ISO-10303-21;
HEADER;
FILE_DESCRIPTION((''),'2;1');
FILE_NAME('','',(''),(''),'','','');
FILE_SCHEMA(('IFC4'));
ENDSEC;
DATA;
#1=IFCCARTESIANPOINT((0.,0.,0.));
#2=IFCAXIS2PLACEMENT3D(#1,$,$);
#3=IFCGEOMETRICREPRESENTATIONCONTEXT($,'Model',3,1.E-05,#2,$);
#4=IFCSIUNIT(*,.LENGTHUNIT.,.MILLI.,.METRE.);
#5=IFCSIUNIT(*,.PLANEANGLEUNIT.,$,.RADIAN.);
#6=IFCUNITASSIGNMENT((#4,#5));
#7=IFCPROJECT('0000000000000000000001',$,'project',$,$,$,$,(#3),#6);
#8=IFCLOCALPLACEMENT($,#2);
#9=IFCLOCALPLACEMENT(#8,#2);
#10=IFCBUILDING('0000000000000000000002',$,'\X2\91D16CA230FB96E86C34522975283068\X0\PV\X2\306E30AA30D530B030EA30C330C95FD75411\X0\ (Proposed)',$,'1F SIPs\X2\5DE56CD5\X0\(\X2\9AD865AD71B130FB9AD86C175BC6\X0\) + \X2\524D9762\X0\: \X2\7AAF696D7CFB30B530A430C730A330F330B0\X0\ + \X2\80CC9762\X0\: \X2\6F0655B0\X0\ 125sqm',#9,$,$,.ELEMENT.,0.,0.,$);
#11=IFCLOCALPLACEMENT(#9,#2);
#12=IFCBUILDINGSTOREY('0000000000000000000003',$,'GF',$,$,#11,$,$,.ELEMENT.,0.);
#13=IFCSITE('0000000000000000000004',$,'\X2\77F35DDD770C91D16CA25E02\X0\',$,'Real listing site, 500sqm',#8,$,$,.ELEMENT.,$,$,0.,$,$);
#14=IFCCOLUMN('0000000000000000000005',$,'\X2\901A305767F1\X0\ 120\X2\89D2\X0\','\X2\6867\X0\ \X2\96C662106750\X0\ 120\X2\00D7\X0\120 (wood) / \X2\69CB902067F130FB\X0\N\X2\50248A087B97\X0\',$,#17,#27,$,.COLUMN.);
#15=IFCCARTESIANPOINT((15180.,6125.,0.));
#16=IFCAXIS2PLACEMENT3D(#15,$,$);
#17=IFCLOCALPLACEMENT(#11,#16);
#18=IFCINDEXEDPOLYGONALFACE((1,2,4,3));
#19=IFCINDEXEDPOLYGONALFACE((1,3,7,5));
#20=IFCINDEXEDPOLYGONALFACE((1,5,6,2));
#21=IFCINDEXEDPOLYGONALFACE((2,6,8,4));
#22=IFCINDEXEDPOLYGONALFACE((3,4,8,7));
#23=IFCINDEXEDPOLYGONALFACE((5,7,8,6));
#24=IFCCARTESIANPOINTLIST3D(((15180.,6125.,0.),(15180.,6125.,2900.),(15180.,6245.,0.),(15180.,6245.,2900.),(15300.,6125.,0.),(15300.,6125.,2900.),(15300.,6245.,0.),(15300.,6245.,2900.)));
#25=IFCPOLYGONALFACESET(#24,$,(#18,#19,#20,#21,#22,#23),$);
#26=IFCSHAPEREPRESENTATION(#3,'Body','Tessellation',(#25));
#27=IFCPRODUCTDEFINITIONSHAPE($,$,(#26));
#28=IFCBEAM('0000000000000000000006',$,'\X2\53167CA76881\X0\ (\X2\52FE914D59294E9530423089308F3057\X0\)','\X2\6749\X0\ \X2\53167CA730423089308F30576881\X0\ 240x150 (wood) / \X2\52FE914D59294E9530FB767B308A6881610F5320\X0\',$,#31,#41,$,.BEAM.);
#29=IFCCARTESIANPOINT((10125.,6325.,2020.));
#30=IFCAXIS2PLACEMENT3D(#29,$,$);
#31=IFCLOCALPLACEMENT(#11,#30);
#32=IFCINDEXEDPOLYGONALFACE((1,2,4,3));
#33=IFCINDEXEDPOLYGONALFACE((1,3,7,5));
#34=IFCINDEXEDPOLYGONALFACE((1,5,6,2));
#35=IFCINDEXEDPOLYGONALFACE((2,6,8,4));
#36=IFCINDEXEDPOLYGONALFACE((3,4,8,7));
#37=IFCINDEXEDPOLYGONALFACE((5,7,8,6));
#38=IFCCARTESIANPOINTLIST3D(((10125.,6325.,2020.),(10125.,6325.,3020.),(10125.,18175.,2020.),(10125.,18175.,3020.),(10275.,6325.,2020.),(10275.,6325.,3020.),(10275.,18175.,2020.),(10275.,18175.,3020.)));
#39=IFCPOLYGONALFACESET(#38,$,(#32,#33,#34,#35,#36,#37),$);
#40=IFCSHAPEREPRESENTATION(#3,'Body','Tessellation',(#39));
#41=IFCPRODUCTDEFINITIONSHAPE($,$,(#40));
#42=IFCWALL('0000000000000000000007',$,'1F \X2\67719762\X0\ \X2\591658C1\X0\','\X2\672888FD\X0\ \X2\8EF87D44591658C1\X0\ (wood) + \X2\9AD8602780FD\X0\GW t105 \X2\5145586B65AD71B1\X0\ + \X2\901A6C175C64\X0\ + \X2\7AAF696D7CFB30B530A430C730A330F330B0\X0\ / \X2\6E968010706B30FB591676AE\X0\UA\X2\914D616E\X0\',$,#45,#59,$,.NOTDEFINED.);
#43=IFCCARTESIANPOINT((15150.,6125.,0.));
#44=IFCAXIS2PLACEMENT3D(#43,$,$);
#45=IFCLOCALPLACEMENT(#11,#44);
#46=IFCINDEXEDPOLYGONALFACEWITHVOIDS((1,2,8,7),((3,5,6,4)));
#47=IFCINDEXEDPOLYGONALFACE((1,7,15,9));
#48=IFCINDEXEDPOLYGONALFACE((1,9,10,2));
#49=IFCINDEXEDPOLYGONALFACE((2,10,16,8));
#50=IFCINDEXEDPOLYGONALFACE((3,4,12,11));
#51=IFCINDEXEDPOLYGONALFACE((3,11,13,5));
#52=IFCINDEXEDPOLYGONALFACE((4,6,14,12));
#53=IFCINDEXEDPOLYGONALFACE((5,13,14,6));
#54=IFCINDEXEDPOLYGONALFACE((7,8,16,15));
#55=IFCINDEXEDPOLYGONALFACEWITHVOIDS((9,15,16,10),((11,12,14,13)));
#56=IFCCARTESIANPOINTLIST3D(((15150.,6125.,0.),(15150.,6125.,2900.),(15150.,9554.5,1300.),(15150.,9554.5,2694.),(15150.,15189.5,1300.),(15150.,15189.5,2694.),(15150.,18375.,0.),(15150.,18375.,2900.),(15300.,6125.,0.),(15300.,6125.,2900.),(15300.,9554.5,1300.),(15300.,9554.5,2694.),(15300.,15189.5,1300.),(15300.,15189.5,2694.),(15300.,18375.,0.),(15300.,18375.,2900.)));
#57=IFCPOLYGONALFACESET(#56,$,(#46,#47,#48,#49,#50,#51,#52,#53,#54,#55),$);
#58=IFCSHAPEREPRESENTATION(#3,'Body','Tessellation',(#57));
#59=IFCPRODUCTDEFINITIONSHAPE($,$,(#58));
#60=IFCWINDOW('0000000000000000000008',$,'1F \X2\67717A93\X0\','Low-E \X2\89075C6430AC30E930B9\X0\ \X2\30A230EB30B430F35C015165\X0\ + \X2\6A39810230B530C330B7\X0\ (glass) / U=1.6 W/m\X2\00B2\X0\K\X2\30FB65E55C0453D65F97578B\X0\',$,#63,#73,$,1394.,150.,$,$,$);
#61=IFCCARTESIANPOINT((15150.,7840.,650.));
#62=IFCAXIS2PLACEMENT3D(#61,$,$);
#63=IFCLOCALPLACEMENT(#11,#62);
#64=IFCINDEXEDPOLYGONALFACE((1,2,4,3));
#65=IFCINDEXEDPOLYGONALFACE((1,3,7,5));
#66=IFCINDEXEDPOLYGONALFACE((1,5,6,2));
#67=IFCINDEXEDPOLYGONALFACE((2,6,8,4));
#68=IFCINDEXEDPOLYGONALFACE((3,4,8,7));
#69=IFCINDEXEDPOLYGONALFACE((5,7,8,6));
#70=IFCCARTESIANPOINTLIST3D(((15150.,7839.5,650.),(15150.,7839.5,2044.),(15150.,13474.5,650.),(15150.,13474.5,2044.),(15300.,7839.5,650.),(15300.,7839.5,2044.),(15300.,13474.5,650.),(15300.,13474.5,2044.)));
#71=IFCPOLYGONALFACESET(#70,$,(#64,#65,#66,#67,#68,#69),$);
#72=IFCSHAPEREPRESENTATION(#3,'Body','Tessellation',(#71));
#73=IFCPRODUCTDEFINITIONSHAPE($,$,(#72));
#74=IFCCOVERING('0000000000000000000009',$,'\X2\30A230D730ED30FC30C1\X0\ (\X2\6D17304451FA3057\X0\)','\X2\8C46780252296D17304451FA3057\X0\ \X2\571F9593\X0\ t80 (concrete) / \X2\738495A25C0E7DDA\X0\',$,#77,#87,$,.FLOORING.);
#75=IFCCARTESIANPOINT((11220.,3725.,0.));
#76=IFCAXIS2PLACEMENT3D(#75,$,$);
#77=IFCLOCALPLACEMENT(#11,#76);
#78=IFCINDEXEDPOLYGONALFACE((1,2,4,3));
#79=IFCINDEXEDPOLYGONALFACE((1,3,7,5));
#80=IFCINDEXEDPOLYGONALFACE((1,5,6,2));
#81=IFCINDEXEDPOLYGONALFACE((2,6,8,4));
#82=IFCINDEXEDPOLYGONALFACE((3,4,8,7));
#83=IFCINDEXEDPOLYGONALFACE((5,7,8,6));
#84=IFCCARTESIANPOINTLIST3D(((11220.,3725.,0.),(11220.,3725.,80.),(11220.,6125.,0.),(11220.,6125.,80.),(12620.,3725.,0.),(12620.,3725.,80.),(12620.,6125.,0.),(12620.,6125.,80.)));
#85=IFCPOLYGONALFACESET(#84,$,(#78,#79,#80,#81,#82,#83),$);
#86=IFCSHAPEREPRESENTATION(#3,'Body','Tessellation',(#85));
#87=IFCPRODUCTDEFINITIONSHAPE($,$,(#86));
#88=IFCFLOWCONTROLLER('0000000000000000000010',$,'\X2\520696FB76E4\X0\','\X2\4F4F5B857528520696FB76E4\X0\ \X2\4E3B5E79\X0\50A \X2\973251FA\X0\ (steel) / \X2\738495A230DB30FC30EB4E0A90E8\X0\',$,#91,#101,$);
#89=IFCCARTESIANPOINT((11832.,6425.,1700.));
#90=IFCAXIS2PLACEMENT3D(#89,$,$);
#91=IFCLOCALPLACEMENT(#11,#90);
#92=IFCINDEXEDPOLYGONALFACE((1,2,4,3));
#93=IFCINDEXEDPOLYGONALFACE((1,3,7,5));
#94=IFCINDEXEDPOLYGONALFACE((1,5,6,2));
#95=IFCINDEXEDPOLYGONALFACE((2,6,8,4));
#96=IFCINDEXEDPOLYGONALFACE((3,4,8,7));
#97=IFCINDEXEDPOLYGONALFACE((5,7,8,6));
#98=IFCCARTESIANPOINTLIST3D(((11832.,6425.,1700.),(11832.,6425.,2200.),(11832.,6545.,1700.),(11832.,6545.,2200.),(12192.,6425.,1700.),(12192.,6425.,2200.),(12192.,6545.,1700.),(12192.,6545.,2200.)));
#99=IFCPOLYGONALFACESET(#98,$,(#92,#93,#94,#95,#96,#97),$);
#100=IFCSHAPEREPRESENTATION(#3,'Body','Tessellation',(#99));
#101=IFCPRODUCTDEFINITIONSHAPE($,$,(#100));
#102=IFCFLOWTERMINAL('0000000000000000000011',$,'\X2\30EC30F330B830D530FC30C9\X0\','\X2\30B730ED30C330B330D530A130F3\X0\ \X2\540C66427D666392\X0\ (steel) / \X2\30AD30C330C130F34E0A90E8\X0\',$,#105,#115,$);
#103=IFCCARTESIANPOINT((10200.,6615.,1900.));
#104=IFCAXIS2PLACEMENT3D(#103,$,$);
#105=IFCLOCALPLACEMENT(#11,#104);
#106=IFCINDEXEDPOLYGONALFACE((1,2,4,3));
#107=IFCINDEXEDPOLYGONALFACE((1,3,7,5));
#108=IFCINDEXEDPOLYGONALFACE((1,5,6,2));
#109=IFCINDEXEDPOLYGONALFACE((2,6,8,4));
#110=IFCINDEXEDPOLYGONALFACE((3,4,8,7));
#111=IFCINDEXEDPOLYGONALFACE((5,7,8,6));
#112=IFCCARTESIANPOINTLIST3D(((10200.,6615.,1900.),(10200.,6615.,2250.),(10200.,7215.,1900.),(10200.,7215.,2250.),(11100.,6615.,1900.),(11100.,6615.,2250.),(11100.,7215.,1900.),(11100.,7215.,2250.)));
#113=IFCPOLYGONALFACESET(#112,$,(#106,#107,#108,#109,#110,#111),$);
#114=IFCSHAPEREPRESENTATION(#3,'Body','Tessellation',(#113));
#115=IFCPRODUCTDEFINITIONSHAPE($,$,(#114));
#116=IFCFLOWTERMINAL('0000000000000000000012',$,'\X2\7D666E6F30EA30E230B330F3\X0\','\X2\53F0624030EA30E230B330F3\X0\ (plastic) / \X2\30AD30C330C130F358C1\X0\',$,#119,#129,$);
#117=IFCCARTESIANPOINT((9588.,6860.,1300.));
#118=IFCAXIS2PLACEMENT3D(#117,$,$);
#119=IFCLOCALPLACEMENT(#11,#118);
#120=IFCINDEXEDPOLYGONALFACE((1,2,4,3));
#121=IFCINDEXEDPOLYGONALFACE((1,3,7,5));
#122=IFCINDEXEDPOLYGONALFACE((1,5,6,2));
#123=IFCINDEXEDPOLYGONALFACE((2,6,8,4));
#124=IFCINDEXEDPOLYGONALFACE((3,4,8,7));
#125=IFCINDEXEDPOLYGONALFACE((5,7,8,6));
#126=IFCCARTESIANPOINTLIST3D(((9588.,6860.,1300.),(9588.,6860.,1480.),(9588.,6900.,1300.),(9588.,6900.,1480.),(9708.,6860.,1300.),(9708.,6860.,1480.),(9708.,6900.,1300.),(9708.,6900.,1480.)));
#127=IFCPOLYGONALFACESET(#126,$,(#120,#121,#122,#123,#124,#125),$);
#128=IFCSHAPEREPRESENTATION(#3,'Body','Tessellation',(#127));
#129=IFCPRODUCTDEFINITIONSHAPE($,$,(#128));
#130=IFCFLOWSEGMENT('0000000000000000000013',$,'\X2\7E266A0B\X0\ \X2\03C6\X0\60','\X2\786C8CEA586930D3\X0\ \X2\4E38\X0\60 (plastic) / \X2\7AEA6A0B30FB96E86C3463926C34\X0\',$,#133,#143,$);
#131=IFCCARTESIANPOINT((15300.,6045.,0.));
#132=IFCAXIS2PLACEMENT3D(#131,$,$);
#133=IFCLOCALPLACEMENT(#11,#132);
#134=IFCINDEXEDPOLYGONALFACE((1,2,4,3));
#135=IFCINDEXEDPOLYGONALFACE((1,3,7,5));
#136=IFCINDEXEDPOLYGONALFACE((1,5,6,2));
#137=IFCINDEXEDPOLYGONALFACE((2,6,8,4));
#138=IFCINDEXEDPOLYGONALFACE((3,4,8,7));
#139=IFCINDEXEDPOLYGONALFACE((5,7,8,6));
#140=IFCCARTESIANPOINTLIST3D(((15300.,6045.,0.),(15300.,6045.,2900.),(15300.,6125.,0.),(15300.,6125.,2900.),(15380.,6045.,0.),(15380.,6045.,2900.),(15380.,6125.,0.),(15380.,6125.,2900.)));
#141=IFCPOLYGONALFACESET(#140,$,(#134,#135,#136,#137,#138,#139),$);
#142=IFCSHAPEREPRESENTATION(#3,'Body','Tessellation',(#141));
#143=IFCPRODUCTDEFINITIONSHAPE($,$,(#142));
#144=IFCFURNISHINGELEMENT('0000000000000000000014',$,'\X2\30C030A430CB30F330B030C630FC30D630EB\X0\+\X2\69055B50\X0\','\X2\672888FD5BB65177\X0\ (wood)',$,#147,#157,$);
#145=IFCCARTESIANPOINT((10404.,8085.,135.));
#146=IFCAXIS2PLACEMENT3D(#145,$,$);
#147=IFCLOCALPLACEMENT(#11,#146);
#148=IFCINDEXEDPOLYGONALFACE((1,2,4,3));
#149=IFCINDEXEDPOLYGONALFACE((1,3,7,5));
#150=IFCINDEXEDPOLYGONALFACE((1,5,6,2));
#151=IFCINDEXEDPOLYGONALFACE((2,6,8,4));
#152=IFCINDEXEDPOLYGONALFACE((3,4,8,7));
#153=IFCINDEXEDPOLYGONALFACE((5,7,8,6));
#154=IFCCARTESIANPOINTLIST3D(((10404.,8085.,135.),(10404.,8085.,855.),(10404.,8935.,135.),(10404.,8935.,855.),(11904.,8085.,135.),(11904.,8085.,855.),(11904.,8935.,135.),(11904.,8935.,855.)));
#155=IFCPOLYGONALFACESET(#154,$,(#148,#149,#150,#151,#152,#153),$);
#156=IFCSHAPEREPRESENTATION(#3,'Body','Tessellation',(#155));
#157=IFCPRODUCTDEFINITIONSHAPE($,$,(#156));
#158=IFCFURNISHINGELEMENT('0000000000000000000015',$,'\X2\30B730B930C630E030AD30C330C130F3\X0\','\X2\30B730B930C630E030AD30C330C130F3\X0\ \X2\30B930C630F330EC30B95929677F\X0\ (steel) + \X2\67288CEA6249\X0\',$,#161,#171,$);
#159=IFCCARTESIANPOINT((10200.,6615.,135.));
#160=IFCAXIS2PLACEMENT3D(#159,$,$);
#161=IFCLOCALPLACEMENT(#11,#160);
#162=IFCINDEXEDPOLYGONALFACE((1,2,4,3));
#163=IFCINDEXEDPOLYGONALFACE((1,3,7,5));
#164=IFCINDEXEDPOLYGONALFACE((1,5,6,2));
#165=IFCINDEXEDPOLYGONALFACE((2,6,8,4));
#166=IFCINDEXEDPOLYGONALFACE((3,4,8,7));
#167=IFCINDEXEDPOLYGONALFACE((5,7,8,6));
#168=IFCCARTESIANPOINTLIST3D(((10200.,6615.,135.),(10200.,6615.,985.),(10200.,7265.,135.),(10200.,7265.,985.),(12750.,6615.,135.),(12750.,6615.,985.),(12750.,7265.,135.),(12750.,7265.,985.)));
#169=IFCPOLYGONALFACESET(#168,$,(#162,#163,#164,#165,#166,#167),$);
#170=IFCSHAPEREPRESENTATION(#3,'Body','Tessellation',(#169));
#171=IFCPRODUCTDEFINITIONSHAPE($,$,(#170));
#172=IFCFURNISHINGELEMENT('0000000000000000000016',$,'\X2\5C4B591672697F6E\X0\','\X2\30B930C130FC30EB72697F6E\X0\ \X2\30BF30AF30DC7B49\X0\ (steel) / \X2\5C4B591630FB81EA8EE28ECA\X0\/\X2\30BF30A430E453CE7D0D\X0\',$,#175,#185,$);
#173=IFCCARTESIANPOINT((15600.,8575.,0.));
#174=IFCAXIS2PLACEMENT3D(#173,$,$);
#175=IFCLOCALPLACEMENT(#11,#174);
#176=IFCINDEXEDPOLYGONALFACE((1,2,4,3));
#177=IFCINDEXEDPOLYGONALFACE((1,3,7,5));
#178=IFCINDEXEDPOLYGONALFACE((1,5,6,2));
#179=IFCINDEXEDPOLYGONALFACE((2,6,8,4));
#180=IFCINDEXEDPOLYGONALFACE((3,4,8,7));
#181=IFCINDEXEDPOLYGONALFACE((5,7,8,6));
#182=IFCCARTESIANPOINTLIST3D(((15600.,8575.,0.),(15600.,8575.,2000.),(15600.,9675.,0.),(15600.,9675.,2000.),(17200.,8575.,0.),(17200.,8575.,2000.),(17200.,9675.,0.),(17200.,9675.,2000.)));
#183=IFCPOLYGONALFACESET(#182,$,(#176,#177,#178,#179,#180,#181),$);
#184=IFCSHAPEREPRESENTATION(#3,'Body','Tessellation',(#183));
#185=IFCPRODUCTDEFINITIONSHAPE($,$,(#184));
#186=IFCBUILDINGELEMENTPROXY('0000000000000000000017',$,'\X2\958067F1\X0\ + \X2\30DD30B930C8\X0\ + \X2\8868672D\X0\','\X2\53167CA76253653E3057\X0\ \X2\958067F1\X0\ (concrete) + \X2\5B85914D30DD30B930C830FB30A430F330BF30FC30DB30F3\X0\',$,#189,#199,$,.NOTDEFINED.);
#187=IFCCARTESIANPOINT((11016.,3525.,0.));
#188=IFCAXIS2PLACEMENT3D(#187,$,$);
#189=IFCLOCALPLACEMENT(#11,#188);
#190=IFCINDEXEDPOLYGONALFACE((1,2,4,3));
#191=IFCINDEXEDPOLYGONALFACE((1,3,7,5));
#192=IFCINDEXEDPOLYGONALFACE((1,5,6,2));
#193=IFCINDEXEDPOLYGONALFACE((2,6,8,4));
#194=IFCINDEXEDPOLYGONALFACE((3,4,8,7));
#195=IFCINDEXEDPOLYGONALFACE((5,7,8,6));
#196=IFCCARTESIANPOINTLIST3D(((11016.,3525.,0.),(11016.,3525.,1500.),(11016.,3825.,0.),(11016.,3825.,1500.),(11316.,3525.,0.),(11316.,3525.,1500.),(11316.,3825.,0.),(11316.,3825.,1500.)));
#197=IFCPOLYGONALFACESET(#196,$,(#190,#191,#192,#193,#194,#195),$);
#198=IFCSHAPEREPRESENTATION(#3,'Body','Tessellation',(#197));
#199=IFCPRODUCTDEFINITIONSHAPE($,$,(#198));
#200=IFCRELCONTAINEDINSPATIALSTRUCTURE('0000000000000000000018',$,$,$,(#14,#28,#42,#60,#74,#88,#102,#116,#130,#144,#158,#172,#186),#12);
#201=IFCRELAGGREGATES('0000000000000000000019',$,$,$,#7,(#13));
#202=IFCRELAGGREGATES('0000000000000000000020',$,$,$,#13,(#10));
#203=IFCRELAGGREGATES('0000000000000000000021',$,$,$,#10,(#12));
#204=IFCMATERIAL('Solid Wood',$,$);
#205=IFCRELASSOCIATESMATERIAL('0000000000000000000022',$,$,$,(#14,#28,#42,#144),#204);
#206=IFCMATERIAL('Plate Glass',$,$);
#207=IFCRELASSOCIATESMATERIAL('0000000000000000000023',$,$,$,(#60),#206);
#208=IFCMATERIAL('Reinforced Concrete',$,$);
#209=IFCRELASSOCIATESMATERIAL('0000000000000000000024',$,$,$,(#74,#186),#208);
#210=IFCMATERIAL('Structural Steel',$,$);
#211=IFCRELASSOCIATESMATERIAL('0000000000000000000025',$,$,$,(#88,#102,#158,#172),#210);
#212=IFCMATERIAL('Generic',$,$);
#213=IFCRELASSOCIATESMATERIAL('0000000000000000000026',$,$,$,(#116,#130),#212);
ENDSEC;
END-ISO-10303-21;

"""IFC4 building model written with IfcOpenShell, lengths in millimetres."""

from ifc_helpers import new_model, si_unit, frame, frame_2d, origin, place, context, project, spatial, rectangle, extrude, material, element, fill, save


model = new_model("IFC4")

# Units and contexts
model_context = context("Model", 3, precision=1e-05, world=origin())
ifc_project = project(units=[si_unit("LENGTHUNIT", "METRE", prefix="MILLI"), si_unit("PLANEANGLEUNIT", "RADIAN")], contexts=[model_context])

# Site, building, storey
site_placement = place(None, origin())
site = spatial("IfcSite", under=ifc_project, at=site_placement, Name="石川県金沢市", ObjectType="Real listing site, 500sqm", CompositionType="ELEMENT", RefElevation=0.0)
building_placement = place(site_placement, origin())
building = spatial("IfcBuilding", under=site, at=building_placement, Name="金沢・雨水利用とPVのオフグリッド志向 (Proposed)", ObjectType="1F SIPs工法(高断熱・高気密) + 前面: 窯業系サイディング + 背面: 漆喰 125sqm", CompositionType="ELEMENT", ElevationOfRefHeight=0.0, ElevationOfTerrain=0.0)
storey_placement = place(building_placement, origin())
storey = spatial("IfcBuildingStorey", under=building, at=storey_placement, Name="GF", CompositionType="ELEMENT", Elevation=0.0)

# Column
ifc_material_1 = material(Name="Solid Wood")
column_1_placement = place(storey_placement, frame((15180.0, 6125.0, 0.0)))
element("IfcColumn", 1, at=column_1_placement, inside=storey, material=ifc_material_1, Name="通し柱 120角", Description="桧 集成材 120×120 (wood) / 構造柱・N値計算", PredefinedType="COLUMN", context=model_context, shape_type="SweptSolid", body=[
    extrude(rectangle(XDim=120.0, YDim=120.0, at=frame_2d((60.0, 60.0))), frame((15180.0, 6125.0, 0.0)), (0.0, 0.0, 1.0), 2900.0),
])

# Beam
beam_1_placement = place(storey_placement, frame((10125.0, 6325.0, 2020.0)))
element("IfcBeam", 2, at=beam_1_placement, inside=storey, material=ifc_material_1, Name="化粧梁 (勾配天井あらわし)", Description="杉 化粧あらわし梁 240x150 (wood) / 勾配天井・登り梁意匠", PredefinedType="BEAM", context=model_context, shape_type="SweptSolid", body=[
    extrude(rectangle(XDim=150.0, YDim=11850.0, at=frame_2d((75.0, 5925.0))), frame((10125.0, 6325.0, 2020.0)), (0.0, 0.0, 1.0), 1000.0),
])

# Wall, opening, window
wall_1_placement = place(storey_placement, frame((15150.0, 6125.0, 0.0)))
wall_1 = element("IfcWall", 3, at=wall_1_placement, inside=storey, material=ifc_material_1, Name="1F 東面 外壁", Description="木製 軸組外壁 (wood) + 高性能GW t105 充填断熱 + 通気層 + 窯業系サイディング / 準耐火・外皮UA配慮", PredefinedType="NOTDEFINED", context=model_context, shape_type="SweptSolid", body=[
    extrude(rectangle(XDim=150.0, YDim=12250.0, at=frame_2d((75.0, 6125.0))), frame((15150.0, 6125.0, 0.0)), (0.0, 0.0, 1.0), 2900.0),
])
opening_placement = place(storey_placement, frame((15150.0, 7840.0, 650.0)))
opening = element("IfcOpeningElement", 4, at=opening_placement, cuts=wall_1, PredefinedType="NOTDEFINED", context=model_context, shape_type="SweptSolid", body=[
    extrude(rectangle(XDim=150.0, YDim=5635.0, at=frame_2d((75.0, 2817.0))), frame((15150.0, 7840.0, 650.0)), (0.0, 0.0, 1.0), 1394.0),
])
ifc_material_2 = material(Name="Plate Glass")
window_placement = place(storey_placement, frame((15150.0, 7840.0, 650.0)))
window = element("IfcWindow", 5, at=window_placement, inside=storey, material=ifc_material_2, Name="1F 東窓", Description="Low-E 複層ガラス アルゴン封入 + 樹脂サッシ (glass) / U=1.6 W/m²K・日射取得型", OverallHeight=1394.0, OverallWidth=150.0, context=model_context, shape_type="SweptSolid", body=[
    extrude(rectangle(XDim=150.0, YDim=5635.0, at=frame_2d((75.0, 2817.0))), frame((15150.0, 7840.0, 650.0)), (0.0, 0.0, 1.0), 1394.0),
])
fill(opening, window)

# Covering
ifc_material_3 = material(Name="Reinforced Concrete")
covering_placement = place(storey_placement, frame((11220.0, 3725.0, 0.0)))
element("IfcCovering", 6, at=covering_placement, inside=storey, material=ifc_material_3, Name="アプローチ (洗い出し)", Description="豆砂利洗い出し 土間 t80 (concrete) / 玄関導線", PredefinedType="FLOORING", context=model_context, shape_type="SweptSolid", body=[
    extrude(rectangle(XDim=1400.0, YDim=2400.0, at=frame_2d((700.0, 1200.0))), frame((11220.0, 3725.0, 0.0)), (0.0, 0.0, 1.0), 80.0),
])

# Flow controller
ifc_material_4 = material(Name="Structural Steel")
flow_controller_placement = place(storey_placement, frame((11832.0, 6425.0, 1700.0)))
element("IfcFlowController", 7, at=flow_controller_placement, inside=storey, material=ifc_material_4, Name="分電盤", Description="住宅用分電盤 主幹50A 露出 (steel) / 玄関ホール上部", context=model_context, shape_type="SweptSolid", body=[
    extrude(rectangle(XDim=360.0, YDim=120.0, at=frame_2d((180.0, 60.0))), frame((11832.0, 6425.0, 1700.0)), (0.0, 0.0, 1.0), 500.0),
])

# Flow terminals
flow_terminal_1_placement = place(storey_placement, frame((10200.0, 6615.0, 1900.0)))
element("IfcFlowTerminal", 8, at=flow_terminal_1_placement, inside=storey, material=ifc_material_4, Name="レンジフード", Description="シロッコファン 同時給排 (steel) / キッチン上部", context=model_context, shape_type="SweptSolid", body=[
    extrude(rectangle(XDim=900.0, YDim=600.0, at=frame_2d((450.0, 300.0))), frame((10200.0, 6615.0, 1900.0)), (0.0, 0.0, 1.0), 350.0),
])
ifc_material_5 = material(Name="Generic")
flow_terminal_2_placement = place(storey_placement, frame((9588.0, 6860.0, 1300.0)))
element("IfcFlowTerminal", 9, at=flow_terminal_2_placement, inside=storey, material=ifc_material_5, Name="給湯リモコン", Description="台所リモコン (plastic) / キッチン壁", context=model_context, shape_type="SweptSolid", body=[
    extrude(rectangle(XDim=120.0, YDim=40.0, at=frame_2d((60.0, 20.0))), frame((9588.0, 6860.0, 1300.0)), (0.0, 0.0, 1.0), 180.0),
])

# Flow segment
flow_segment_placement = place(storey_placement, frame((15300.0, 6045.0, 0.0)))
element("IfcFlowSegment", 10, at=flow_segment_placement, inside=storey, material=ifc_material_5, Name="縦樋 φ60", Description="硬質塩ビ 丸60 (plastic) / 竪樋・雨水排水", context=model_context, shape_type="SweptSolid", body=[
    extrude(rectangle(XDim=80.0, YDim=80.0, at=frame_2d((40.0, 40.0))), frame((15300.0, 6045.0, 0.0)), (0.0, 0.0, 1.0), 2900.0),
])

# Furnishing elements
furnishing_1_placement = place(storey_placement, frame((10404.0, 8085.0, 135.0)))
element("IfcFurnishingElement", 11, at=furnishing_1_placement, inside=storey, material=ifc_material_1, Name="ダイニングテーブル+椅子", Description="木製家具 (wood)", context=model_context, shape_type="SweptSolid", body=[
    extrude(rectangle(XDim=1500.0, YDim=850.0, at=frame_2d((750.0, 425.0))), frame((10404.0, 8085.0, 135.0)), (0.0, 0.0, 1.0), 720.0),
])
furnishing_2_placement = place(storey_placement, frame((10200.0, 6615.0, 135.0)))
element("IfcFurnishingElement", 12, at=furnishing_2_placement, inside=storey, material=ifc_material_4, Name="システムキッチン", Description="システムキッチン ステンレス天板 (steel) + 木質扉", context=model_context, shape_type="SweptSolid", body=[
    extrude(rectangle(XDim=2550.0, YDim=650.0, at=frame_2d((1275.0, 325.0))), frame((10200.0, 6615.0, 135.0)), (0.0, 0.0, 1.0), 850.0),
])
furnishing_3_placement = place(storey_placement, frame((15600.0, 8575.0, 0.0)))
element("IfcFurnishingElement", 13, at=furnishing_3_placement, inside=storey, material=ifc_material_4, Name="屋外物置", Description="スチール物置 タクボ等 (steel) / 屋外・自転車/タイヤ収納", context=model_context, shape_type="SweptSolid", body=[
    extrude(rectangle(XDim=1600.0, YDim=1100.0, at=frame_2d((800.0, 550.0))), frame((15600.0, 8575.0, 0.0)), (0.0, 0.0, 1.0), 2000.0),
])

# Building element proxy
proxy_placement = place(storey_placement, frame((11016.0, 3525.0, 0.0)))
element("IfcBuildingElementProxy", 14, at=proxy_placement, inside=storey, material=ifc_material_3, Name="門柱 + ポスト + 表札", Description="化粧打放し 門柱 (concrete) + 宅配ポスト・インターホン", PredefinedType="NOTDEFINED", context=model_context, shape_type="SweptSolid", body=[
    extrude(rectangle(XDim=300.0, YDim=300.0, at=frame_2d((150.0, 150.0))), frame((11016.0, 3525.0, 0.0)), (0.0, 0.0, 1.0), 1500.0),
])

save(model, "model.ifc")
